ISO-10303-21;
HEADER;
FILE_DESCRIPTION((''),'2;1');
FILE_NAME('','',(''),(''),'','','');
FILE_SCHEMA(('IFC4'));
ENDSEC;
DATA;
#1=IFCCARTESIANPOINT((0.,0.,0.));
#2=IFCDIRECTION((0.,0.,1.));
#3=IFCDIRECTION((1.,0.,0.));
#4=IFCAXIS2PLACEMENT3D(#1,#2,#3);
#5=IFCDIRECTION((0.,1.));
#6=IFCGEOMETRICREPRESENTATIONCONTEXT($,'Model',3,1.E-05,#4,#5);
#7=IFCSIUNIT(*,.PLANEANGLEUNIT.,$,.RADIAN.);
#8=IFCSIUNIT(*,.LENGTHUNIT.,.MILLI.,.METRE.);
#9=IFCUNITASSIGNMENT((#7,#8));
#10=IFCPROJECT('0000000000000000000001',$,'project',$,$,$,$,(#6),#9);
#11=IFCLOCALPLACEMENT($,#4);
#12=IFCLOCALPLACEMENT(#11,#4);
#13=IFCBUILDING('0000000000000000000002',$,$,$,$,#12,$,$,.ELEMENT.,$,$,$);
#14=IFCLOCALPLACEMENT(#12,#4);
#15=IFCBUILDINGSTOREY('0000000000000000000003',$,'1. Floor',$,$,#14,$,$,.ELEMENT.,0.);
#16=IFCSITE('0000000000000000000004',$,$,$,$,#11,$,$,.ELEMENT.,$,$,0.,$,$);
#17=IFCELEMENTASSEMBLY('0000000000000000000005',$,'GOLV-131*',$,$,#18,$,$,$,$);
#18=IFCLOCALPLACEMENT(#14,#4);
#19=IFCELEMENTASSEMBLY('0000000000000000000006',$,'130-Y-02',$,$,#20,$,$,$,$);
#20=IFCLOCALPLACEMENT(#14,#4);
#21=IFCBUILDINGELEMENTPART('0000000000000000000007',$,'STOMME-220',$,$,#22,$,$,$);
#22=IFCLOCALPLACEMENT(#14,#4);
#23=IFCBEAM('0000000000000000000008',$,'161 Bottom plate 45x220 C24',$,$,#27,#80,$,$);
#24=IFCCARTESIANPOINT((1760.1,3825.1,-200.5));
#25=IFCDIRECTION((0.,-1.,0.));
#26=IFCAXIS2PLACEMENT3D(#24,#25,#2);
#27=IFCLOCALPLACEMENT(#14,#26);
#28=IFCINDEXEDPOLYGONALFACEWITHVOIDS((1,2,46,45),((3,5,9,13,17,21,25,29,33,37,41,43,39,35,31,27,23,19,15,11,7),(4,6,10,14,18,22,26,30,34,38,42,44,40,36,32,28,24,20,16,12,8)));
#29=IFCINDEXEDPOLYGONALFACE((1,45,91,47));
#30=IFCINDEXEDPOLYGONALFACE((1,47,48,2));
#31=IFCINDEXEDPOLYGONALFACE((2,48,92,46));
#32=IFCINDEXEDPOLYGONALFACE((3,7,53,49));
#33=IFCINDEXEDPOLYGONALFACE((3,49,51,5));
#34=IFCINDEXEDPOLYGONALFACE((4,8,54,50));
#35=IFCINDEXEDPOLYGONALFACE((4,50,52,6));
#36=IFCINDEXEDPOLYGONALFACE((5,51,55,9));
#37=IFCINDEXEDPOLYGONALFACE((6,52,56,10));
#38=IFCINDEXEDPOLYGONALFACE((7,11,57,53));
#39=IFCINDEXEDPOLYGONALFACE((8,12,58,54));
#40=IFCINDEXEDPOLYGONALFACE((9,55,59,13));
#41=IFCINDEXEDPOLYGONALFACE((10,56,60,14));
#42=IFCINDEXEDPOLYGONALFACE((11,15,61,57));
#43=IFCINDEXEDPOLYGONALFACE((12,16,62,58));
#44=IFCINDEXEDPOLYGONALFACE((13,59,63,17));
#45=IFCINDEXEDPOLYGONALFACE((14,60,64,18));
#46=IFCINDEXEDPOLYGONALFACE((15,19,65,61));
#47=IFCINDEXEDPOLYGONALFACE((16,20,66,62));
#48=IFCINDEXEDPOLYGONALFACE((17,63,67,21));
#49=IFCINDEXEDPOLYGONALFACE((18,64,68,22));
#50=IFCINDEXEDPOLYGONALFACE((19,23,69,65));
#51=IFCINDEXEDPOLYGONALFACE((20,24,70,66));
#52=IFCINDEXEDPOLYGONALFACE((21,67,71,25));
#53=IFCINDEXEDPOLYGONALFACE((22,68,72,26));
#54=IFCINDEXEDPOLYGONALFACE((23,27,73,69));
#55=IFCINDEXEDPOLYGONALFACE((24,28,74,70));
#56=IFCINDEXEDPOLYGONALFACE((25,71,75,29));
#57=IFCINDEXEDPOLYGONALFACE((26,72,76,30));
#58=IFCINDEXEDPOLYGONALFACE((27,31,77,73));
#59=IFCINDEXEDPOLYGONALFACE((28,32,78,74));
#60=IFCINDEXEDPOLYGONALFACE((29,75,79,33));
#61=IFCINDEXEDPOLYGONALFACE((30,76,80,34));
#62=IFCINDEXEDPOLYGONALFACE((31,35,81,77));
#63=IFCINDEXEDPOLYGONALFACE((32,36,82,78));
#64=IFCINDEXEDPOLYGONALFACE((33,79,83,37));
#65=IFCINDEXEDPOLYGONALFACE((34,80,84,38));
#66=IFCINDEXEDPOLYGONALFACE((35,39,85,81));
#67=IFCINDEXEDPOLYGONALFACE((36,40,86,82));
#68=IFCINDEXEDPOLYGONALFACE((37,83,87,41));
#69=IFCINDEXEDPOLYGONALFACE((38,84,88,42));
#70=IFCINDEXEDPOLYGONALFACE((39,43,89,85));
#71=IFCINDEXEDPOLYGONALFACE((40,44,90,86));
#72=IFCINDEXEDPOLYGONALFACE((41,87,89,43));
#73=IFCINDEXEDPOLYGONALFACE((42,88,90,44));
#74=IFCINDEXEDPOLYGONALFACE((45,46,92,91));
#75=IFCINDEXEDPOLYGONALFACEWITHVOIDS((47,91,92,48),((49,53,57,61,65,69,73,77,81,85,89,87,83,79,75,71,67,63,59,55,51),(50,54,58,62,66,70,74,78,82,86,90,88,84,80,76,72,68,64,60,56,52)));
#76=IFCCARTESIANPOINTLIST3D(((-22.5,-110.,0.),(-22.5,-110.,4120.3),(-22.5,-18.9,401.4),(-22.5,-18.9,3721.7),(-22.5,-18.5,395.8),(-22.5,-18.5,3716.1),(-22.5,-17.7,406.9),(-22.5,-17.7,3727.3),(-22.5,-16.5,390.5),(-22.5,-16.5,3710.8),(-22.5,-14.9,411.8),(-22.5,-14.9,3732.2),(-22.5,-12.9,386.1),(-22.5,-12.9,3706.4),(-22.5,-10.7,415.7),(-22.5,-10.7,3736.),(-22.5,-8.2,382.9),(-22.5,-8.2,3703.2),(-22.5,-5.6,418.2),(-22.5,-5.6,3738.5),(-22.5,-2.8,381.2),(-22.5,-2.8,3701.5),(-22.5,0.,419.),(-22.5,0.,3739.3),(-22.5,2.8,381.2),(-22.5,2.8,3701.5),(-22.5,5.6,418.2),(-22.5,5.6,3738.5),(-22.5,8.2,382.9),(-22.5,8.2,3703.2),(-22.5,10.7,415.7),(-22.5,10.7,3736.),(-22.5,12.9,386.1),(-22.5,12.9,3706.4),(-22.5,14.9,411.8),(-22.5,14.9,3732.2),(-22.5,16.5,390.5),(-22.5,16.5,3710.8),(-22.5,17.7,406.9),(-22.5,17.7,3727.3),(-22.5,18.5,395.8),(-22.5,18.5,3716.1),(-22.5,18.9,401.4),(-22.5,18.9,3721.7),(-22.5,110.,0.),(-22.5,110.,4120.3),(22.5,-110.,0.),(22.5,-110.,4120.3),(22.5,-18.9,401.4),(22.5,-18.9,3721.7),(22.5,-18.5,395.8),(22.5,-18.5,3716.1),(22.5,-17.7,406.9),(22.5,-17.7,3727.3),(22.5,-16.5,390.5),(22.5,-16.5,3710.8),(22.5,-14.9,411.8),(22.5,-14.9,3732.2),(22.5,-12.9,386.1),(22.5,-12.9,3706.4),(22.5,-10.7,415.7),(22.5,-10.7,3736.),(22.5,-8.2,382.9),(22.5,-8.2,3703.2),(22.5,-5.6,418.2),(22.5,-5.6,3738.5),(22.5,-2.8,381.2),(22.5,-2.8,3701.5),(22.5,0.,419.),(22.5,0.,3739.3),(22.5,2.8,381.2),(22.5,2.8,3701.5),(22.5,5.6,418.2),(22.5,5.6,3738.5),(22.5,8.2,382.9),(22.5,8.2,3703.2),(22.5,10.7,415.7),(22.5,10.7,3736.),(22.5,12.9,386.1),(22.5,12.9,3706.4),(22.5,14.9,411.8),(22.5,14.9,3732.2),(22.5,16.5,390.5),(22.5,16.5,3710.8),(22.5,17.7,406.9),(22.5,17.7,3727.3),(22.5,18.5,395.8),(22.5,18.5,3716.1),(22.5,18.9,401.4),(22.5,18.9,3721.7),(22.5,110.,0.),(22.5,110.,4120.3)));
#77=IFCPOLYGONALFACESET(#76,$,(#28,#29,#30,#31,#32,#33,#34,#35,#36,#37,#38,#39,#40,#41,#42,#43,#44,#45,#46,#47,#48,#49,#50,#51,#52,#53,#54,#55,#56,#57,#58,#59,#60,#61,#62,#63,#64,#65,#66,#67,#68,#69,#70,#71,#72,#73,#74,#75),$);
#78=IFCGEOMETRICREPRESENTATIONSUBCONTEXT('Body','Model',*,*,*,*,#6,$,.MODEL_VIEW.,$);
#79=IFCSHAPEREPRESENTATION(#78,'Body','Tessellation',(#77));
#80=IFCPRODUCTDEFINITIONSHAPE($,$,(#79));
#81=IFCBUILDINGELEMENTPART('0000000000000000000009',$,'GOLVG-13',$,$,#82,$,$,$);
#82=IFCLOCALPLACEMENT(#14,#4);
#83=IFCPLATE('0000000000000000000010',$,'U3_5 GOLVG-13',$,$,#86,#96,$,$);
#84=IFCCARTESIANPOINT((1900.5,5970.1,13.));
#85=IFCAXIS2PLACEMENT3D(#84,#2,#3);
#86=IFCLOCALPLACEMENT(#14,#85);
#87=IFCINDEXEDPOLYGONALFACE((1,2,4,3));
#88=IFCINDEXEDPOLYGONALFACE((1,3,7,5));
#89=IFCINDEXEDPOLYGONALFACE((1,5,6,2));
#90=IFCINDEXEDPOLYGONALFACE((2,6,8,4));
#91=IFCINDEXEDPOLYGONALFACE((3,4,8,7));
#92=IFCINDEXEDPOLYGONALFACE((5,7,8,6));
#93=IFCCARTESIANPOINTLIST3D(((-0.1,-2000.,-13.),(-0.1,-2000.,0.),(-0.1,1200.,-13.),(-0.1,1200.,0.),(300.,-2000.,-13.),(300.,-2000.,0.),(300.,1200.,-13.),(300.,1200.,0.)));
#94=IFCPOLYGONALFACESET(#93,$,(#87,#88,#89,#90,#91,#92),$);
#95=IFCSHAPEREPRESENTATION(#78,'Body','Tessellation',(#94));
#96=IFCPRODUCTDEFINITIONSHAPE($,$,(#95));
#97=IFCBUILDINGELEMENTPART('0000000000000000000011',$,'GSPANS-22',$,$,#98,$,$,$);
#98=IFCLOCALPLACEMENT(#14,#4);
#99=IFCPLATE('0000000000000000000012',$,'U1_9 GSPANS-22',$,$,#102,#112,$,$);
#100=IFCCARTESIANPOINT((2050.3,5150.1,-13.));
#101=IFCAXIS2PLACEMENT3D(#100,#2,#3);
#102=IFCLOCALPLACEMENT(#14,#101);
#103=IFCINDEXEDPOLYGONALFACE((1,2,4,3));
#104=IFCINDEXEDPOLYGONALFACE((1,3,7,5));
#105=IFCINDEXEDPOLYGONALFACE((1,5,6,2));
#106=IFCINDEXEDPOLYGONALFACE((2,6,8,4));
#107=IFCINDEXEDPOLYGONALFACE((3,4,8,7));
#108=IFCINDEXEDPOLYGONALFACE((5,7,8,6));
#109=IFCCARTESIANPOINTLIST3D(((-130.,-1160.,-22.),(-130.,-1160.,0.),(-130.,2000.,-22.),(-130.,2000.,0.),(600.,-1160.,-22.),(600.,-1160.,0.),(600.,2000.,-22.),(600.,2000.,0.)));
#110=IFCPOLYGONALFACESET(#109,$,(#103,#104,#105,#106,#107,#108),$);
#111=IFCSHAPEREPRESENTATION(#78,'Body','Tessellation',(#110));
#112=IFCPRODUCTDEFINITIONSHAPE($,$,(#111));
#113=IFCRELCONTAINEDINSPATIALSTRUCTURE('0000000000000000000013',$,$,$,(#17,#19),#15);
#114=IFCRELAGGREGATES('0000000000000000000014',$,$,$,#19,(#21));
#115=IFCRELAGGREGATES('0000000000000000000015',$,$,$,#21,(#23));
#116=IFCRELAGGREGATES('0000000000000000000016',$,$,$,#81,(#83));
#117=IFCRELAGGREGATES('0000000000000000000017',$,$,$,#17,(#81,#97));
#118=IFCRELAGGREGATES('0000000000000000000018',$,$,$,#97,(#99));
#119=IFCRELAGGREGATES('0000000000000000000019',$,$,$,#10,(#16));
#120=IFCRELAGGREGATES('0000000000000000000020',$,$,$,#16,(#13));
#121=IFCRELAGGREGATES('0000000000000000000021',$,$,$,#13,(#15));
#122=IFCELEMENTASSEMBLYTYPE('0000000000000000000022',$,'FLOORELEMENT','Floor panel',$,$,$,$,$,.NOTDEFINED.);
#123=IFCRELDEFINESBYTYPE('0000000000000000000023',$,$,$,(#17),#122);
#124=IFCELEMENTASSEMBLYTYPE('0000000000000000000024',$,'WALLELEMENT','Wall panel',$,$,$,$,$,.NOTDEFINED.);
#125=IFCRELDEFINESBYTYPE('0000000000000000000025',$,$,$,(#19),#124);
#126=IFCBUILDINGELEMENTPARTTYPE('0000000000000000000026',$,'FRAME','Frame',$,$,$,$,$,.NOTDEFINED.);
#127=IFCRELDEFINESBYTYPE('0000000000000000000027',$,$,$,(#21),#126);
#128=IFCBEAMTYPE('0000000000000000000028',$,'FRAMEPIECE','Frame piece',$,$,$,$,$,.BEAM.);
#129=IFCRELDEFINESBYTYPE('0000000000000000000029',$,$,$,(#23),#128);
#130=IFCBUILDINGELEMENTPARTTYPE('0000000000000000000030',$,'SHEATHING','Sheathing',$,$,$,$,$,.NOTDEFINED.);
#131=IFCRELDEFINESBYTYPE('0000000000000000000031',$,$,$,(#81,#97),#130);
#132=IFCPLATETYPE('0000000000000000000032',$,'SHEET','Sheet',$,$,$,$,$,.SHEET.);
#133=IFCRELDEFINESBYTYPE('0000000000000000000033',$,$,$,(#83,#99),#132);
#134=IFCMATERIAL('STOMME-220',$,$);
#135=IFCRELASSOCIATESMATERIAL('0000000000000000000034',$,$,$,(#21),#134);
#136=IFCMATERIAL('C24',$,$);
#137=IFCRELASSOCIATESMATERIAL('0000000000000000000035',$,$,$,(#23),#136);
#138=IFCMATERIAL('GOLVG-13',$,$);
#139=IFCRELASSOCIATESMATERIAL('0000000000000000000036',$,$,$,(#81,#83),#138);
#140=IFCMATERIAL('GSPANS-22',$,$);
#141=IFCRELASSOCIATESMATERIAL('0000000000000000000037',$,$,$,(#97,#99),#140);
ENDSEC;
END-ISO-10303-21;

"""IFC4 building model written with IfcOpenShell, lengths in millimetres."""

from ifc_helpers import new_model, si_unit, direction, frame, origin_with_axes, origin_2d_with_axis, place, context, subcontext, project, spatial, rectangle, circle, extrude, boolean, material, type_object, element, aggregate, save


model = new_model("IFC4")

# Units and contexts
model_context = context("Model", 3, precision=1e-05, world=origin_with_axes(), true_north=direction((0.0, 1.0)))
body_context = subcontext(model_context, "Body", "Model", "MODEL_VIEW")
ifc_project = project(units=[si_unit("PLANEANGLEUNIT", "RADIAN"), si_unit("LENGTHUNIT", "METRE", prefix="MILLI")], contexts=[model_context])

# Site, building, storey
site_placement = place(None, origin_with_axes())
site = spatial("IfcSite", under=ifc_project, at=site_placement, CompositionType="ELEMENT", RefElevation=0.0)
building_placement = place(site_placement, origin_with_axes())
building = spatial("IfcBuilding", under=site, at=building_placement, CompositionType="ELEMENT")
storey_placement = place(building_placement, origin_with_axes())
storey = spatial("IfcBuildingStorey", under=building, at=storey_placement, Name="1. Floor", CompositionType="ELEMENT", Elevation=0.0)

# Shared definitions
element_assembly_type_1 = type_object("IfcElementAssemblyType", Name="WALLELEMENT", Description="Wall panel", PredefinedType="NOTDEFINED")
ifc_material_1 = material(Name="STOMME-220")
building_element_part_type_1 = type_object("IfcBuildingElementPartType", Name="FRAME", Description="Frame", PredefinedType="NOTDEFINED")
ifc_material_2 = material(Name="C24")

# Element assembly
element_assembly_type_2 = type_object("IfcElementAssemblyType", Name="FLOORELEMENT", Description="Floor panel", PredefinedType="NOTDEFINED")
assembly_1_placement = place(storey_placement, origin_with_axes())
assembly_1 = element("IfcElementAssembly", 1, at=assembly_1_placement, inside=storey, type_object=element_assembly_type_2, Name="GOLV-131*")
beam_type_1 = type_object("IfcBeamType", Name="FRAMEPIECE", Description="Frame piece", PredefinedType="BEAM")

# Element assembly, building element part, beam
assembly_2_placement = place(storey_placement, origin_with_axes())
assembly_2 = element("IfcElementAssembly", 2, at=assembly_2_placement, inside=storey, type_object=element_assembly_type_1, Name="130-Y-02")
building_element_part_1_placement = place(storey_placement, origin_with_axes())
building_element_part_1 = element("IfcBuildingElementPart", 3, at=building_element_part_1_placement, type_object=building_element_part_type_1, material=ifc_material_1, Name="STOMME-220")
aggregate(assembly_2, [building_element_part_1])
beam_1_placement = place(storey_placement, frame((1760.1, 3825.1, -200.5), z_axis=(0.0, -1.0, 0.0), x_axis=(0.0, 0.0, 1.0)))
beam_1 = element("IfcBeam", 4, at=beam_1_placement, type_object=beam_type_1, material=ifc_material_2, Name="161 Bottom plate 45x220 C24", context=body_context, shape_type="CSG", body=[
    boolean("DIFFERENCE", boolean("DIFFERENCE", extrude(rectangle(XDim=45.0, YDim=220.0, at=origin_2d_with_axis()), origin_with_axes(), (0.0, 0.0, 1.0), 4120.3), extrude(circle(Radius=19.0, at=origin_2d_with_axis()), frame((-45.0, 0.0, 400.0), z_axis=(-1.0, 0.0, 0.0), x_axis=(0.0, 0.0, 1.0)), (0.0, 0.0, -1.0), 90.0)), extrude(circle(Radius=19.0, at=origin_2d_with_axis()), frame((-45.0, 0.0, 3720.3), z_axis=(-1.0, 0.0, 0.0), x_axis=(0.0, 0.0, 1.0)), (0.0, 0.0, -1.0), 90.0)),
])
aggregate(building_element_part_1, [beam_1])

# Building element part, plate
ifc_material_3 = material(Name="GOLVG-13")
building_element_part_type_2 = type_object("IfcBuildingElementPartType", Name="SHEATHING", Description="Sheathing", PredefinedType="NOTDEFINED")
building_element_part_2_placement = place(storey_placement, origin_with_axes())
building_element_part_2 = element("IfcBuildingElementPart", 5, at=building_element_part_2_placement, type_object=building_element_part_type_2, material=ifc_material_3, Name="GOLVG-13")
plate_type_1 = type_object("IfcPlateType", Name="SHEET", Description="Sheet", PredefinedType="SHEET")
plate_1_placement = place(storey_placement, frame((1900.5, 5970.1, 13.0), z_axis=(0.0, 0.0, 1.0), x_axis=(1.0, 0.0, 0.0)))
plate_1 = element("IfcPlate", 6, at=plate_1_placement, type_object=plate_type_1, material=ifc_material_3, Name="U3_5 GOLVG-13", context=body_context, shape_type="SweptSolid", body=[
    extrude(rectangle(XDim=13.0, YDim=300.1, at=origin_2d_with_axis()), frame((149.9, -2000.0, -6.5), z_axis=(0.0, 1.0, 0.0), x_axis=(0.0, 0.0, 1.0)), (0.0, 0.0, 1.0), 3200.0),
])
aggregate(building_element_part_2, [plate_1])

# Building element part
ifc_material_4 = material(Name="GSPANS-22")
building_element_part_3_placement = place(storey_placement, origin_with_axes())
building_element_part_3 = element("IfcBuildingElementPart", 7, at=building_element_part_3_placement, type_object=building_element_part_type_2, material=ifc_material_4, Name="GSPANS-22")
aggregate(assembly_1, [building_element_part_2, building_element_part_3])

# Plate
plate_2_placement = place(storey_placement, frame((2050.3, 5150.1, -13.0), z_axis=(0.0, 0.0, 1.0), x_axis=(1.0, 0.0, 0.0)))
plate_2 = element("IfcPlate", 8, at=plate_2_placement, type_object=plate_type_1, material=ifc_material_4, Name="U1_9 GSPANS-22", context=body_context, shape_type="SweptSolid", body=[
    extrude(rectangle(XDim=22.0, YDim=730.0, at=origin_2d_with_axis()), frame((235.0, -1160.0, -11.0), z_axis=(0.0, 1.0, 0.0), x_axis=(0.0, 0.0, 1.0)), (0.0, 0.0, 1.0), 3160.0),
])
aggregate(building_element_part_3, [plate_2])

save(model, "model.ifc")
